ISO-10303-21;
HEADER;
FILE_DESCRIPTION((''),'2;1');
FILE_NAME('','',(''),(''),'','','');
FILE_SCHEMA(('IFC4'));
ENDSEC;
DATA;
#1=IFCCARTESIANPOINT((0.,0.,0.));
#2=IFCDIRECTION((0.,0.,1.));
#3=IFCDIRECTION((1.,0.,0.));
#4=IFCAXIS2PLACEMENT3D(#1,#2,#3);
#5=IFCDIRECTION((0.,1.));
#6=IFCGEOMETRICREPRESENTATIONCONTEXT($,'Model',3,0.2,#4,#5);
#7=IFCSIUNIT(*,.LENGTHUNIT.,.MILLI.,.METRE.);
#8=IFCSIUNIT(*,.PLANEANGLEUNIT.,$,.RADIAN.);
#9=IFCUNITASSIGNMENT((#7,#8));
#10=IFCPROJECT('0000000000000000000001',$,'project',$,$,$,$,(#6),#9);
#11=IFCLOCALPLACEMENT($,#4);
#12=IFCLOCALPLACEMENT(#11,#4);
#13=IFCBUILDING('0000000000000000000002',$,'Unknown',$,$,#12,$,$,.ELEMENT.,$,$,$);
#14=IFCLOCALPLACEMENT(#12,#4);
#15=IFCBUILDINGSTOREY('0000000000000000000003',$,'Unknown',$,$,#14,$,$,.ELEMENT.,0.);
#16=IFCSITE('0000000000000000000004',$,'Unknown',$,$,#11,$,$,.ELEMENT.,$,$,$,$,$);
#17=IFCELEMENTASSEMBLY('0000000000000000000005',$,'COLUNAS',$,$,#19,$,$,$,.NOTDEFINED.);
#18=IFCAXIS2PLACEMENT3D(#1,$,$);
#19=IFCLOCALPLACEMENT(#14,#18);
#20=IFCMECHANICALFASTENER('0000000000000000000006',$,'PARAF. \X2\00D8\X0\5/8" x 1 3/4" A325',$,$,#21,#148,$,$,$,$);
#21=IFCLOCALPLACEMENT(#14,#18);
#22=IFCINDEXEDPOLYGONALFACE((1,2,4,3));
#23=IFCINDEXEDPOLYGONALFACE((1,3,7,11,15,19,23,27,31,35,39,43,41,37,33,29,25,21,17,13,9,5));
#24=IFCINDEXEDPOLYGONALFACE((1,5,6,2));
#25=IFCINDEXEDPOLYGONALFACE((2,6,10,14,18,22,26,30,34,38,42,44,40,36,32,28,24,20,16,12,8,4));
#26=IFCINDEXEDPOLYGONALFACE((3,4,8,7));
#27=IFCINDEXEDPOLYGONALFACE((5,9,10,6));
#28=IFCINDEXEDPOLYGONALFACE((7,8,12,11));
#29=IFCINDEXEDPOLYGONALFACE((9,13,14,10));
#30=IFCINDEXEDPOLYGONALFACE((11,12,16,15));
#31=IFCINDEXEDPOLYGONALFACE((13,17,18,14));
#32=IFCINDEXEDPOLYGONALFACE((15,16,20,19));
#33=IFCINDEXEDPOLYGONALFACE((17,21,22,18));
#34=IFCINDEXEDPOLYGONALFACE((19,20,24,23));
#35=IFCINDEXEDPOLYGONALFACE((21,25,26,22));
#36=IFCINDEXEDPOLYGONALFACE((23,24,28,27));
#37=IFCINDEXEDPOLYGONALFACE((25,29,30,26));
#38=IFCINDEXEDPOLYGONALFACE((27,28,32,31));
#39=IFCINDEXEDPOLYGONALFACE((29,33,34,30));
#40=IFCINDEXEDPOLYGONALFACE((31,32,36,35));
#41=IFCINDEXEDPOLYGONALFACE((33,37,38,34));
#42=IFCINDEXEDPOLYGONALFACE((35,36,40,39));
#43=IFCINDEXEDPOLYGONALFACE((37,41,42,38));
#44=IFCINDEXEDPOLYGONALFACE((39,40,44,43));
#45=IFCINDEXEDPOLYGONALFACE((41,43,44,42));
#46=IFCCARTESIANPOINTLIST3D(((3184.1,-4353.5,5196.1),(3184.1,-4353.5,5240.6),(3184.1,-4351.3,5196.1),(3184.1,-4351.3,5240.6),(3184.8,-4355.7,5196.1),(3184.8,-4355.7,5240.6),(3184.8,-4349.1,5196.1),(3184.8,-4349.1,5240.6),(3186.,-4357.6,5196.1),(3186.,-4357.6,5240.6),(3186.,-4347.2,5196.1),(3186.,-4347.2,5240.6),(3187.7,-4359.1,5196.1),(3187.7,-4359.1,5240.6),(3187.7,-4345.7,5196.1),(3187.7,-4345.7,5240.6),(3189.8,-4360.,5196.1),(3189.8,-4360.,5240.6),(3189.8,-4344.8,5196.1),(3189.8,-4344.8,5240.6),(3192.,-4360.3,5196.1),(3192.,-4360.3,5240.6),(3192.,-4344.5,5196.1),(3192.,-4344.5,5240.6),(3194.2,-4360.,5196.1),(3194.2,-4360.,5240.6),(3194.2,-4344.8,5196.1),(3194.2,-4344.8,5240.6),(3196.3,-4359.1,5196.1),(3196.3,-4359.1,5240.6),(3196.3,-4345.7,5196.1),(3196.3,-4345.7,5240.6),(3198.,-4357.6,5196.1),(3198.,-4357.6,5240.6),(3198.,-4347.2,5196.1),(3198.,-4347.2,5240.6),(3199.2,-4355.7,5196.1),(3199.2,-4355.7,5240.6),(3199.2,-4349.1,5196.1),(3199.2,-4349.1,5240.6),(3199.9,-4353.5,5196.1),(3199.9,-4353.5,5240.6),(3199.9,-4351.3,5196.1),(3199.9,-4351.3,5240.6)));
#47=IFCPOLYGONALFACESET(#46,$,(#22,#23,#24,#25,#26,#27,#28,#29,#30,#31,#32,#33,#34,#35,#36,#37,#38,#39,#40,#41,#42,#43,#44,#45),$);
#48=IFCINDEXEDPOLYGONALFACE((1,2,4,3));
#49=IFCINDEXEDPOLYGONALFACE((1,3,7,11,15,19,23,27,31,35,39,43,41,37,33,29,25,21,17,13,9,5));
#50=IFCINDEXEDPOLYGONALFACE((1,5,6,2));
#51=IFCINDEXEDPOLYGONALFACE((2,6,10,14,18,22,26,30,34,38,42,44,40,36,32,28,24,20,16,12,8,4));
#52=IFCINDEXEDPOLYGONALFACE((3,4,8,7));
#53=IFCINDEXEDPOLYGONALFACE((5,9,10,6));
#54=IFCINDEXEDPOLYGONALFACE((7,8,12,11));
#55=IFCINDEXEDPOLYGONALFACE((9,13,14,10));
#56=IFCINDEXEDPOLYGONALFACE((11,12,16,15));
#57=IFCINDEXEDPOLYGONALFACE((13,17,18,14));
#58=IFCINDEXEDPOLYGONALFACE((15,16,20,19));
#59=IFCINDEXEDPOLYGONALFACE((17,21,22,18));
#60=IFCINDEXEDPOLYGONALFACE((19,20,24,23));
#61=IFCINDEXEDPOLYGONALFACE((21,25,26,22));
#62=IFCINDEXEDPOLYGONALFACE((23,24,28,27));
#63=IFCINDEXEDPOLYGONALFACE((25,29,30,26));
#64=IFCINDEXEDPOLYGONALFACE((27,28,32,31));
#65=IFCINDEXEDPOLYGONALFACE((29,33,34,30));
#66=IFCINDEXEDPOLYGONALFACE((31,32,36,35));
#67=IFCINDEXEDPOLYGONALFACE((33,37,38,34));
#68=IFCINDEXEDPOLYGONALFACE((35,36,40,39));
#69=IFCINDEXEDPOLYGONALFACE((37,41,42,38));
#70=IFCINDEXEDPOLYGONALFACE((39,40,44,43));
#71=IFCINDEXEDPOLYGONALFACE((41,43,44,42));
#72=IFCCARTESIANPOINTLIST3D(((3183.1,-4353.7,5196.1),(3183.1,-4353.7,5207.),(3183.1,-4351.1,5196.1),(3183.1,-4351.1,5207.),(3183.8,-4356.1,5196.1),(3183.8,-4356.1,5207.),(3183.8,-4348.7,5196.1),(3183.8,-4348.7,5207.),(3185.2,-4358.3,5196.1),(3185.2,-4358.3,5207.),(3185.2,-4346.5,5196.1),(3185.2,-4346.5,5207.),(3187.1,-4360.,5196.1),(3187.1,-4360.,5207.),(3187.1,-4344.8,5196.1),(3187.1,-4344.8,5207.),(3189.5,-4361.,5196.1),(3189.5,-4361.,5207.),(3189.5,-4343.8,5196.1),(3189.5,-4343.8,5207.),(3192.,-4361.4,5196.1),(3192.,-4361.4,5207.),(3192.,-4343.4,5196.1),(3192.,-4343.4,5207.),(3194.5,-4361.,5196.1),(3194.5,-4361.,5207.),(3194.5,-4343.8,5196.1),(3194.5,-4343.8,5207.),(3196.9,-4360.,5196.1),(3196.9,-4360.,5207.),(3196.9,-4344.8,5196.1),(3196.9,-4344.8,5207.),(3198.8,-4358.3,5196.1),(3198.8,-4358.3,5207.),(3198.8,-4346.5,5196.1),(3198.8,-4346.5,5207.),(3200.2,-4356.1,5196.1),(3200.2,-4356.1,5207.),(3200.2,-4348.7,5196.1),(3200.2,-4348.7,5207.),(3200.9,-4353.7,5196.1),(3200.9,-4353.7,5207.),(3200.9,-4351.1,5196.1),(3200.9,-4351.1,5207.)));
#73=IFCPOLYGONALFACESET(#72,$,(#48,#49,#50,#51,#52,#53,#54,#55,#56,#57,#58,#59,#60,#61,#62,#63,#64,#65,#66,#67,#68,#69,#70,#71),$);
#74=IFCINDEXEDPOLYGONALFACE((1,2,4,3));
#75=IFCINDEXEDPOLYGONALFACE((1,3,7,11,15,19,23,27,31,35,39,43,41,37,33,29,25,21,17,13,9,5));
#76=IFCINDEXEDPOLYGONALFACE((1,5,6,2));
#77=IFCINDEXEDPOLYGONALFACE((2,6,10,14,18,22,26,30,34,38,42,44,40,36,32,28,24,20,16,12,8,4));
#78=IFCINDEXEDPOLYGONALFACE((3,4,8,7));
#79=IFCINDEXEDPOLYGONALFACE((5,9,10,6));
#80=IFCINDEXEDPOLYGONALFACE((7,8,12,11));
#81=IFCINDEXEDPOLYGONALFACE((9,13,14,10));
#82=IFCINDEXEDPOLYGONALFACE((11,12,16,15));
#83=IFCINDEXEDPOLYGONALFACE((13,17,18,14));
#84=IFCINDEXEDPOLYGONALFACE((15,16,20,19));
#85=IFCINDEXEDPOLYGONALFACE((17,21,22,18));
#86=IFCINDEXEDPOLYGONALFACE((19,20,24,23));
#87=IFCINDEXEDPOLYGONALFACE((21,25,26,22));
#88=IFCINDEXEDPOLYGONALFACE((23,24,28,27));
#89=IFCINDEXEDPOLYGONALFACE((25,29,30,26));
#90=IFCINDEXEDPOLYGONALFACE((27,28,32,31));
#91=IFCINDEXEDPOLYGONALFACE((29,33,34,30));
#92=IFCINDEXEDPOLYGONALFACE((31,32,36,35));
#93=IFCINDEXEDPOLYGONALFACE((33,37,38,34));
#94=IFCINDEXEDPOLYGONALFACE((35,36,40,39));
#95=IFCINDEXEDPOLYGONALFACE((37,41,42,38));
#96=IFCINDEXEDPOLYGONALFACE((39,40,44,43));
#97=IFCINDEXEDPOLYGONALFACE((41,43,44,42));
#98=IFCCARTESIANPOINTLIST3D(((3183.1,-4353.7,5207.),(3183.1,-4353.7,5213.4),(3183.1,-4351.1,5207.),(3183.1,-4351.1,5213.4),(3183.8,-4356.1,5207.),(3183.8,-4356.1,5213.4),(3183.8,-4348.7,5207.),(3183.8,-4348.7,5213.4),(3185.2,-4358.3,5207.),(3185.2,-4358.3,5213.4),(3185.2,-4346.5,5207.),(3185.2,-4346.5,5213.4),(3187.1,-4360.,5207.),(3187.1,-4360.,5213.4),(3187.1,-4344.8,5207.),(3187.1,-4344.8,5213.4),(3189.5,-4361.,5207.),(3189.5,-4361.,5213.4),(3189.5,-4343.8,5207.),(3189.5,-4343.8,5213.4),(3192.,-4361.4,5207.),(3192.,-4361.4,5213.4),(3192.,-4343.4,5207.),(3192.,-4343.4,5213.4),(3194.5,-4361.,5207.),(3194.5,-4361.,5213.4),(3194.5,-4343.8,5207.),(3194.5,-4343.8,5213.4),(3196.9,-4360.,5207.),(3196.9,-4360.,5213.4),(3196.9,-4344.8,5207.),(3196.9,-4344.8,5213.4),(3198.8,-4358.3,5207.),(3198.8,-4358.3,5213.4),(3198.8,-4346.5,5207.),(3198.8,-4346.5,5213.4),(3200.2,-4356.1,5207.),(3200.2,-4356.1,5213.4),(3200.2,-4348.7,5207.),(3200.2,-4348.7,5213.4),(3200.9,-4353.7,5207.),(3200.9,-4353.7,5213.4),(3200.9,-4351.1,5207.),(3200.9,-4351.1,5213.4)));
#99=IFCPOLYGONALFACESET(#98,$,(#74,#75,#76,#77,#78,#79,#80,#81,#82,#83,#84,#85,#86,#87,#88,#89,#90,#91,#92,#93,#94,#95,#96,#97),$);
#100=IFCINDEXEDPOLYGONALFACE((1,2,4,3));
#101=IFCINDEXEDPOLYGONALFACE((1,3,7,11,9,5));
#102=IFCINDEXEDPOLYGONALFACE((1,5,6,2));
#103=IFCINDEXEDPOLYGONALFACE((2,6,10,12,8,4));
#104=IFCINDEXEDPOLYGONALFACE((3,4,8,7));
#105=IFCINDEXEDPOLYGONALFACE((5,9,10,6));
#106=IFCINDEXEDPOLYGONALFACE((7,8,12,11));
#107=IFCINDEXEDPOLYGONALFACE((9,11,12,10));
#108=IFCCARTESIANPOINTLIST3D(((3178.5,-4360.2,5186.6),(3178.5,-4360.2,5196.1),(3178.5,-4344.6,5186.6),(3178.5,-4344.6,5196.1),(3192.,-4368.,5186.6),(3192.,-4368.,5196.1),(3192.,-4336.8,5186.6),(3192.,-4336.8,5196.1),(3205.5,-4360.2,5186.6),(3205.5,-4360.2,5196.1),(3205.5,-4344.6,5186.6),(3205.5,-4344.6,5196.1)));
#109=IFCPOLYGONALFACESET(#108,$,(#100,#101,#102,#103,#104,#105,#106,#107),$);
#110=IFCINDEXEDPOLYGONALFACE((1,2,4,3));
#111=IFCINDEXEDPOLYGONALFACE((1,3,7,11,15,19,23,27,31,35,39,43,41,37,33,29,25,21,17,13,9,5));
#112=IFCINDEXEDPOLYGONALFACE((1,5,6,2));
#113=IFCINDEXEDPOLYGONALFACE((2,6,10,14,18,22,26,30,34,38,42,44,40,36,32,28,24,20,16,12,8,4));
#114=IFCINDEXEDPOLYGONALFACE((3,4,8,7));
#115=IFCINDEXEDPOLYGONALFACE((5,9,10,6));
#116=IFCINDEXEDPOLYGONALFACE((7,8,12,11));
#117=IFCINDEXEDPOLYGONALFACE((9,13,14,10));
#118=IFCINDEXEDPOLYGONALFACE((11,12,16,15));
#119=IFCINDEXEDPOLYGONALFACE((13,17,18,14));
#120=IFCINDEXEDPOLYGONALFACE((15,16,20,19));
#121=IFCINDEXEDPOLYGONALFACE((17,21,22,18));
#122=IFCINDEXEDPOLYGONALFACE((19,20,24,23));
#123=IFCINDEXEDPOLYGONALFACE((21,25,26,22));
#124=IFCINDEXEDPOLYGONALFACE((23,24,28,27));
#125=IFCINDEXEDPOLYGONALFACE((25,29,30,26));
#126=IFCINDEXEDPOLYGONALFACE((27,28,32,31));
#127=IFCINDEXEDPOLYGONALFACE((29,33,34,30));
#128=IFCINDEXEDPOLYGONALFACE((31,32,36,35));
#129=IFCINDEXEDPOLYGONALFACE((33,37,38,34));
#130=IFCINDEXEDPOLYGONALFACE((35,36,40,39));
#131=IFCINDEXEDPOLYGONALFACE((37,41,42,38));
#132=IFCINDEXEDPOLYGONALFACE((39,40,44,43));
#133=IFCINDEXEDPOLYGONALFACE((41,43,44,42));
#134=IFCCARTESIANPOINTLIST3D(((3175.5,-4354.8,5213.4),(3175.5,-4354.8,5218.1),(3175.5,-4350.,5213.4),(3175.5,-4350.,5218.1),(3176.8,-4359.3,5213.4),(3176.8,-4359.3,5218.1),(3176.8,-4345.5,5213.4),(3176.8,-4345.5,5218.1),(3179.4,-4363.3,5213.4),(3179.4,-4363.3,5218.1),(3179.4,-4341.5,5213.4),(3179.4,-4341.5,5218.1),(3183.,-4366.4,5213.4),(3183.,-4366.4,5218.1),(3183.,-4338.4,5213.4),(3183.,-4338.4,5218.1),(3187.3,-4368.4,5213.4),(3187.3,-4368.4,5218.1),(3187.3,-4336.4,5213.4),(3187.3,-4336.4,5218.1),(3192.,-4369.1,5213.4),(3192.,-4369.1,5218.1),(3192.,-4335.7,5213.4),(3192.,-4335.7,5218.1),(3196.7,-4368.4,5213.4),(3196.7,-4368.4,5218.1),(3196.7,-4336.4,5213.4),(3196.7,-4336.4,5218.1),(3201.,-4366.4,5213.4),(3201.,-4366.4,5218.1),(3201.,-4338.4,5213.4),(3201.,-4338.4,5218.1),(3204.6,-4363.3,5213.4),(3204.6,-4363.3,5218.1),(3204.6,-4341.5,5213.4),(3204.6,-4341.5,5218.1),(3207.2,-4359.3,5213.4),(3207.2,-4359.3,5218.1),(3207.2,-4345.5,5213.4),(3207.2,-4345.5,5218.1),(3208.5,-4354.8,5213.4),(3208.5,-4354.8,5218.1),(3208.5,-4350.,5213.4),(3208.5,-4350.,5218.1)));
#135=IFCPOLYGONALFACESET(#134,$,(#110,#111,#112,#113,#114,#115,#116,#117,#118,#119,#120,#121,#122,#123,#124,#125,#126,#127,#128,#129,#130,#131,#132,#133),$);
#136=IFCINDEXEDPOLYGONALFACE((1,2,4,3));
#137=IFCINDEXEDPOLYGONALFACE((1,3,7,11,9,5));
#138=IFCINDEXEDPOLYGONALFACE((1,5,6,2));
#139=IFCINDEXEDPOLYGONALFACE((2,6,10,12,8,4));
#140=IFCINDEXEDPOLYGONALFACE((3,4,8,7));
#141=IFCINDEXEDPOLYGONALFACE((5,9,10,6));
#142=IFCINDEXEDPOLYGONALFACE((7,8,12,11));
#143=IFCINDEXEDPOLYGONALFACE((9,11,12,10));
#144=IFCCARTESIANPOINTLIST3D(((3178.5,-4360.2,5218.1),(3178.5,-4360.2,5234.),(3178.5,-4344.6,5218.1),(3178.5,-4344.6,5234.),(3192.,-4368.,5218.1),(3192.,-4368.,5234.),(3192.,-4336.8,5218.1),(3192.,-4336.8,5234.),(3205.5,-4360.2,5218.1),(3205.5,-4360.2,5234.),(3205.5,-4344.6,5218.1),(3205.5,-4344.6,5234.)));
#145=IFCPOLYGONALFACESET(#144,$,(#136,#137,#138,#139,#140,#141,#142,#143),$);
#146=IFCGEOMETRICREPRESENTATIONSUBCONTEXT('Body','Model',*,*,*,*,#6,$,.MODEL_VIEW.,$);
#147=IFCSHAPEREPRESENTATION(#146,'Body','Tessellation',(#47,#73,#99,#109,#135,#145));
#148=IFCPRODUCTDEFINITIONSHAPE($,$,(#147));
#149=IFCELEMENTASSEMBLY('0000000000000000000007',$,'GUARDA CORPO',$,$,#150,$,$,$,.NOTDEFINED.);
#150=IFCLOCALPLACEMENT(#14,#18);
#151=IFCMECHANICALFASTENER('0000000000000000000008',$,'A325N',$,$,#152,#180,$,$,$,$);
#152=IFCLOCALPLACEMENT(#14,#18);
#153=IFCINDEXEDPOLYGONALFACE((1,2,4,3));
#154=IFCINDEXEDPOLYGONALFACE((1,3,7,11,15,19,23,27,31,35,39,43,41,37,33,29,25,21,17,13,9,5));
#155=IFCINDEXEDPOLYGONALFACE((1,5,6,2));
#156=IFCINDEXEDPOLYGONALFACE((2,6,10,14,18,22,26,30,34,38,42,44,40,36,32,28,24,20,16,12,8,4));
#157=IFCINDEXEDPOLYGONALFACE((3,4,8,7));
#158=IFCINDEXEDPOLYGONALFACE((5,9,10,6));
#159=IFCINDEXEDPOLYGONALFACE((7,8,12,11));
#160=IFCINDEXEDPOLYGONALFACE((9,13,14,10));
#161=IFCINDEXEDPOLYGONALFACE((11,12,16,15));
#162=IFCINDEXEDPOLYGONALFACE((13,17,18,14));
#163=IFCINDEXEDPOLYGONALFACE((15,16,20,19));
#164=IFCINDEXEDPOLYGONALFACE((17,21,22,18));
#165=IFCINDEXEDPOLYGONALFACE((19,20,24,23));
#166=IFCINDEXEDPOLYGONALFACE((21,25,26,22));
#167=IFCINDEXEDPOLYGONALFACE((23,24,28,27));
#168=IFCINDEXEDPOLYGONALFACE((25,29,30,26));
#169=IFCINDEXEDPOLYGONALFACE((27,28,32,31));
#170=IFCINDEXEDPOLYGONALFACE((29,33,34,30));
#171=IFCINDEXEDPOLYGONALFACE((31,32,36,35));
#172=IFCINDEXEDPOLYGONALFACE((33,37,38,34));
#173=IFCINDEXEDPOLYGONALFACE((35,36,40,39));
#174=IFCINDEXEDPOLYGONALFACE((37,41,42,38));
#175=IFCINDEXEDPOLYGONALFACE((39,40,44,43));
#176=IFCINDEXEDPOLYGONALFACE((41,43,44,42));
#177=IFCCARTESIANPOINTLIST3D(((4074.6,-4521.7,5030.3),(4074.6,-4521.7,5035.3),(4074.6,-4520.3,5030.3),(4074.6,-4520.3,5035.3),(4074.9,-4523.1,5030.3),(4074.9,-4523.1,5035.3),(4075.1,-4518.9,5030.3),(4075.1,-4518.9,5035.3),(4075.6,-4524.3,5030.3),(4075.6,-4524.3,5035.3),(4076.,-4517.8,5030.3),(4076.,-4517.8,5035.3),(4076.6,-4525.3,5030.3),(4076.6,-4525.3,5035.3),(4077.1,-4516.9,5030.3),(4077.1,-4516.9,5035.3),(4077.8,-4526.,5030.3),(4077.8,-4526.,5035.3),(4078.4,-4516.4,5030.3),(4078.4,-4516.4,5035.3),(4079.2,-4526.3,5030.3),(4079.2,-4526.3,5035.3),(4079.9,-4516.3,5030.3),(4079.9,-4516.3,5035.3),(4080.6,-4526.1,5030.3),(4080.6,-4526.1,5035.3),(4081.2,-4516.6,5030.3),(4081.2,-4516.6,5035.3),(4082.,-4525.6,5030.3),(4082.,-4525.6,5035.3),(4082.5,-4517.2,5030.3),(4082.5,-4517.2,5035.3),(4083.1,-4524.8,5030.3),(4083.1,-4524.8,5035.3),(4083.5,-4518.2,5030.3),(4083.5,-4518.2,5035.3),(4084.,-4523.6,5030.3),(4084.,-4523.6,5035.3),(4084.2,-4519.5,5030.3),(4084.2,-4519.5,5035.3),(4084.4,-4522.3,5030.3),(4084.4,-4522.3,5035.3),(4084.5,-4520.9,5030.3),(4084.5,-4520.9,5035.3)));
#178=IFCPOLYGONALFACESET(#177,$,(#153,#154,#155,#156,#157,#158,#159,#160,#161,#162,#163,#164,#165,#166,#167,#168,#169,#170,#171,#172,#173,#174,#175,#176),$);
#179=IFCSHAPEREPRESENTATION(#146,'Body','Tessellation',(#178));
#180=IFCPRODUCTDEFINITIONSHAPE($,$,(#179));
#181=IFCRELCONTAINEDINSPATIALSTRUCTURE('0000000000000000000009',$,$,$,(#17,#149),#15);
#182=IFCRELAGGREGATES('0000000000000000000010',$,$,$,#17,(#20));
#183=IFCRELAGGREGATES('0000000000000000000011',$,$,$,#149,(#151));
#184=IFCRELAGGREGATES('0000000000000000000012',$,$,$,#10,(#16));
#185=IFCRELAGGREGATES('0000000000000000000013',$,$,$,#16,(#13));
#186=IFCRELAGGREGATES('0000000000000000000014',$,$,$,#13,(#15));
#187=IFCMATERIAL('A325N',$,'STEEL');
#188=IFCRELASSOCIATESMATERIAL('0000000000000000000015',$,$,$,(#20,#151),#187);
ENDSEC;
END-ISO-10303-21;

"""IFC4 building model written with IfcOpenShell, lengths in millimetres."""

from ifc_helpers import new_model, si_unit, direction, frame, origin_with_axes, place, context, subcontext, project, spatial, line, arc, indexed_curve, outline, extrude, source, transform, mapped, material, element, aggregate, save


model = new_model("IFC4")

# Units and contexts
model_context = context("Model", 3, precision=0.2, world=origin_with_axes(), true_north=direction((0.0, 1.0)))
body_context = subcontext(model_context, "Body", "Model", "MODEL_VIEW")
ifc_project = project(units=[si_unit("LENGTHUNIT", "METRE", prefix="MILLI"), si_unit("PLANEANGLEUNIT", "RADIAN")], contexts=[model_context])

# Site, building, storey
site_placement = place(None, origin_with_axes())
site = spatial("IfcSite", under=ifc_project, at=site_placement, Name="Unknown", CompositionType="ELEMENT")
building_placement = place(site_placement, origin_with_axes())
building = spatial("IfcBuilding", under=site, at=building_placement, Name="Unknown", CompositionType="ELEMENT")
storey_placement = place(building_placement, origin_with_axes())
storey = spatial("IfcBuildingStorey", under=building, at=storey_placement, Name="Unknown", CompositionType="ELEMENT", Elevation=0.0)

# Element assembly
assembly_1_placement = place(storey_placement, frame((3129.5, -4354.0, 5210.0), z_axis=(0.0, -1.0, 0.0), x_axis=(0.0, 0.0, 1.0)))
assembly_1 = element("IfcElementAssembly", 1, at=assembly_1_placement, inside=storey, Name="COLUNAS", PredefinedType="NOTDEFINED")

# Shared definitions
ifc_material_1 = material(Name="A325N", Category="STEEL")

# Mechanical fastener
shared_shape_1 = source(origin_with_axes(), body_context, "Body", "SweptSolid", [
    extrude(outline(indexed_curve([(7.9, 0.0), (0.0, 7.9), (-7.9, 0.0), (0.0, -7.9)], segments=[arc(1, 2, 3), arc(3, 4, 1)])), frame((0.0, 0.0, 17.2), z_axis=(0.0, 0.0, -1.0), x_axis=(0.0, 1.0, 0.0)), (0.0, 0.0, 1.0), 44.5),
    extrude(outline(indexed_curve([(9.0, 0.0), (0.0, 9.0), (-9.0, 0.0), (0.0, -9.0)], segments=[arc(1, 2, 3), arc(3, 4, 1)])), frame((0.0, 0.0, 17.2), z_axis=(0.0, 0.0, -1.0), x_axis=(0.0, 1.0, 0.0)), (0.0, 0.0, 1.0), 10.9),
    extrude(outline(indexed_curve([(9.0, 0.0), (0.0, 9.0), (-9.0, 0.0), (0.0, -9.0)], segments=[arc(1, 2, 3), arc(3, 4, 1)])), frame((0.0, 0.0, 6.3), z_axis=(0.0, 0.0, -1.0), x_axis=(0.0, 1.0, 0.0)), (0.0, 0.0, 1.0), 6.4),
    extrude(outline(indexed_curve([(15.6, 0.0), (7.8, 13.5), (-7.8, 13.5), (-15.6, 0.0), (-7.8, -13.5), (7.8, -13.5)], segments=[line(1, 2, 3, 4, 5, 6, 1)])), frame((0.0, 0.0, 26.8), z_axis=(0.0, 0.0, -1.0), x_axis=(0.0, 1.0, 0.0)), (0.0, 0.0, 1.0), 9.5),
    extrude(outline(indexed_curve([(16.7, 0.0), (0.0, 16.7), (-16.7, 0.0), (0.0, -16.7)], segments=[arc(1, 2, 3), arc(3, 4, 1)])), frame((0.0, 0.0, 0.0), z_axis=(0.0, 0.0, -1.0), x_axis=(0.0, 1.0, 0.0)), (0.0, 0.0, 1.0), 4.8),
    extrude(outline(indexed_curve([(15.6, 0.0), (7.8, 13.5), (-7.8, 13.5), (-15.6, 0.0), (-7.8, -13.5), (7.8, -13.5)], segments=[line(1, 2, 3, 4, 5, 6, 1)])), frame((0.0, 0.0, -4.8), z_axis=(0.0, 0.0, -1.0), x_axis=(0.0, 1.0, 0.0)), (0.0, 0.0, 1.0), 15.9),
])
mechanical_fastener_1_placement = place(assembly_1_placement, frame((3.3, -62.5, -1.6), z_axis=(-1.0, 0.0, 0.0), x_axis=(0.0, -1.0, 0.0)))
mechanical_fastener_1 = element("IfcMechanicalFastener", 2, at=mechanical_fastener_1_placement, material=ifc_material_1, Name="PARAF. Ø5/8\" x 1 3/4\" A325", context=body_context, shape_type="MappedRepresentation", body=[
    mapped(shared_shape_1, transform((0.0, 0.0, 0.0))),
])
aggregate(assembly_1, [mechanical_fastener_1])

# Element assembly
assembly_2_placement = place(storey_placement, frame((4079.6, -3637.9, 5215.0), z_axis=(-1.0, 0.000512, -0.000003), x_axis=(-0.000003, -0.000003, 1.0)))
assembly_2 = element("IfcElementAssembly", 3, at=assembly_2_placement, inside=storey, Name="GUARDA CORPO", PredefinedType="NOTDEFINED")

# Mechanical fastener
shared_shape_2 = source(origin_with_axes(), body_context, "Body", "SweptSolid", [
    extrude(outline(indexed_curve([(5.0, 0.0), (0.0, 5.0), (-5.0, 0.0), (0.0, -5.0)], segments=[arc(1, 2, 3), arc(3, 4, 1)])), frame((0.0, 0.0, 0.0), z_axis=(0.0, 0.0, -1.0), x_axis=(0.0, 1.0, 0.0)), (0.0, 0.0, 1.0), 5.0),
])
mechanical_fastener_2_placement = place(assembly_2_placement, frame((-179.7, -883.3, -0.4), z_axis=(1.0, 0.000005, -0.000003), x_axis=(0.000005, -0.882404, 0.470493)))
mechanical_fastener_2 = element("IfcMechanicalFastener", 4, at=mechanical_fastener_2_placement, material=ifc_material_1, Name="A325N", context=body_context, shape_type="MappedRepresentation", body=[
    mapped(shared_shape_2, transform((0.0, 0.0, 0.0))),
])
aggregate(assembly_2, [mechanical_fastener_2])

save(model, "model.ifc")
